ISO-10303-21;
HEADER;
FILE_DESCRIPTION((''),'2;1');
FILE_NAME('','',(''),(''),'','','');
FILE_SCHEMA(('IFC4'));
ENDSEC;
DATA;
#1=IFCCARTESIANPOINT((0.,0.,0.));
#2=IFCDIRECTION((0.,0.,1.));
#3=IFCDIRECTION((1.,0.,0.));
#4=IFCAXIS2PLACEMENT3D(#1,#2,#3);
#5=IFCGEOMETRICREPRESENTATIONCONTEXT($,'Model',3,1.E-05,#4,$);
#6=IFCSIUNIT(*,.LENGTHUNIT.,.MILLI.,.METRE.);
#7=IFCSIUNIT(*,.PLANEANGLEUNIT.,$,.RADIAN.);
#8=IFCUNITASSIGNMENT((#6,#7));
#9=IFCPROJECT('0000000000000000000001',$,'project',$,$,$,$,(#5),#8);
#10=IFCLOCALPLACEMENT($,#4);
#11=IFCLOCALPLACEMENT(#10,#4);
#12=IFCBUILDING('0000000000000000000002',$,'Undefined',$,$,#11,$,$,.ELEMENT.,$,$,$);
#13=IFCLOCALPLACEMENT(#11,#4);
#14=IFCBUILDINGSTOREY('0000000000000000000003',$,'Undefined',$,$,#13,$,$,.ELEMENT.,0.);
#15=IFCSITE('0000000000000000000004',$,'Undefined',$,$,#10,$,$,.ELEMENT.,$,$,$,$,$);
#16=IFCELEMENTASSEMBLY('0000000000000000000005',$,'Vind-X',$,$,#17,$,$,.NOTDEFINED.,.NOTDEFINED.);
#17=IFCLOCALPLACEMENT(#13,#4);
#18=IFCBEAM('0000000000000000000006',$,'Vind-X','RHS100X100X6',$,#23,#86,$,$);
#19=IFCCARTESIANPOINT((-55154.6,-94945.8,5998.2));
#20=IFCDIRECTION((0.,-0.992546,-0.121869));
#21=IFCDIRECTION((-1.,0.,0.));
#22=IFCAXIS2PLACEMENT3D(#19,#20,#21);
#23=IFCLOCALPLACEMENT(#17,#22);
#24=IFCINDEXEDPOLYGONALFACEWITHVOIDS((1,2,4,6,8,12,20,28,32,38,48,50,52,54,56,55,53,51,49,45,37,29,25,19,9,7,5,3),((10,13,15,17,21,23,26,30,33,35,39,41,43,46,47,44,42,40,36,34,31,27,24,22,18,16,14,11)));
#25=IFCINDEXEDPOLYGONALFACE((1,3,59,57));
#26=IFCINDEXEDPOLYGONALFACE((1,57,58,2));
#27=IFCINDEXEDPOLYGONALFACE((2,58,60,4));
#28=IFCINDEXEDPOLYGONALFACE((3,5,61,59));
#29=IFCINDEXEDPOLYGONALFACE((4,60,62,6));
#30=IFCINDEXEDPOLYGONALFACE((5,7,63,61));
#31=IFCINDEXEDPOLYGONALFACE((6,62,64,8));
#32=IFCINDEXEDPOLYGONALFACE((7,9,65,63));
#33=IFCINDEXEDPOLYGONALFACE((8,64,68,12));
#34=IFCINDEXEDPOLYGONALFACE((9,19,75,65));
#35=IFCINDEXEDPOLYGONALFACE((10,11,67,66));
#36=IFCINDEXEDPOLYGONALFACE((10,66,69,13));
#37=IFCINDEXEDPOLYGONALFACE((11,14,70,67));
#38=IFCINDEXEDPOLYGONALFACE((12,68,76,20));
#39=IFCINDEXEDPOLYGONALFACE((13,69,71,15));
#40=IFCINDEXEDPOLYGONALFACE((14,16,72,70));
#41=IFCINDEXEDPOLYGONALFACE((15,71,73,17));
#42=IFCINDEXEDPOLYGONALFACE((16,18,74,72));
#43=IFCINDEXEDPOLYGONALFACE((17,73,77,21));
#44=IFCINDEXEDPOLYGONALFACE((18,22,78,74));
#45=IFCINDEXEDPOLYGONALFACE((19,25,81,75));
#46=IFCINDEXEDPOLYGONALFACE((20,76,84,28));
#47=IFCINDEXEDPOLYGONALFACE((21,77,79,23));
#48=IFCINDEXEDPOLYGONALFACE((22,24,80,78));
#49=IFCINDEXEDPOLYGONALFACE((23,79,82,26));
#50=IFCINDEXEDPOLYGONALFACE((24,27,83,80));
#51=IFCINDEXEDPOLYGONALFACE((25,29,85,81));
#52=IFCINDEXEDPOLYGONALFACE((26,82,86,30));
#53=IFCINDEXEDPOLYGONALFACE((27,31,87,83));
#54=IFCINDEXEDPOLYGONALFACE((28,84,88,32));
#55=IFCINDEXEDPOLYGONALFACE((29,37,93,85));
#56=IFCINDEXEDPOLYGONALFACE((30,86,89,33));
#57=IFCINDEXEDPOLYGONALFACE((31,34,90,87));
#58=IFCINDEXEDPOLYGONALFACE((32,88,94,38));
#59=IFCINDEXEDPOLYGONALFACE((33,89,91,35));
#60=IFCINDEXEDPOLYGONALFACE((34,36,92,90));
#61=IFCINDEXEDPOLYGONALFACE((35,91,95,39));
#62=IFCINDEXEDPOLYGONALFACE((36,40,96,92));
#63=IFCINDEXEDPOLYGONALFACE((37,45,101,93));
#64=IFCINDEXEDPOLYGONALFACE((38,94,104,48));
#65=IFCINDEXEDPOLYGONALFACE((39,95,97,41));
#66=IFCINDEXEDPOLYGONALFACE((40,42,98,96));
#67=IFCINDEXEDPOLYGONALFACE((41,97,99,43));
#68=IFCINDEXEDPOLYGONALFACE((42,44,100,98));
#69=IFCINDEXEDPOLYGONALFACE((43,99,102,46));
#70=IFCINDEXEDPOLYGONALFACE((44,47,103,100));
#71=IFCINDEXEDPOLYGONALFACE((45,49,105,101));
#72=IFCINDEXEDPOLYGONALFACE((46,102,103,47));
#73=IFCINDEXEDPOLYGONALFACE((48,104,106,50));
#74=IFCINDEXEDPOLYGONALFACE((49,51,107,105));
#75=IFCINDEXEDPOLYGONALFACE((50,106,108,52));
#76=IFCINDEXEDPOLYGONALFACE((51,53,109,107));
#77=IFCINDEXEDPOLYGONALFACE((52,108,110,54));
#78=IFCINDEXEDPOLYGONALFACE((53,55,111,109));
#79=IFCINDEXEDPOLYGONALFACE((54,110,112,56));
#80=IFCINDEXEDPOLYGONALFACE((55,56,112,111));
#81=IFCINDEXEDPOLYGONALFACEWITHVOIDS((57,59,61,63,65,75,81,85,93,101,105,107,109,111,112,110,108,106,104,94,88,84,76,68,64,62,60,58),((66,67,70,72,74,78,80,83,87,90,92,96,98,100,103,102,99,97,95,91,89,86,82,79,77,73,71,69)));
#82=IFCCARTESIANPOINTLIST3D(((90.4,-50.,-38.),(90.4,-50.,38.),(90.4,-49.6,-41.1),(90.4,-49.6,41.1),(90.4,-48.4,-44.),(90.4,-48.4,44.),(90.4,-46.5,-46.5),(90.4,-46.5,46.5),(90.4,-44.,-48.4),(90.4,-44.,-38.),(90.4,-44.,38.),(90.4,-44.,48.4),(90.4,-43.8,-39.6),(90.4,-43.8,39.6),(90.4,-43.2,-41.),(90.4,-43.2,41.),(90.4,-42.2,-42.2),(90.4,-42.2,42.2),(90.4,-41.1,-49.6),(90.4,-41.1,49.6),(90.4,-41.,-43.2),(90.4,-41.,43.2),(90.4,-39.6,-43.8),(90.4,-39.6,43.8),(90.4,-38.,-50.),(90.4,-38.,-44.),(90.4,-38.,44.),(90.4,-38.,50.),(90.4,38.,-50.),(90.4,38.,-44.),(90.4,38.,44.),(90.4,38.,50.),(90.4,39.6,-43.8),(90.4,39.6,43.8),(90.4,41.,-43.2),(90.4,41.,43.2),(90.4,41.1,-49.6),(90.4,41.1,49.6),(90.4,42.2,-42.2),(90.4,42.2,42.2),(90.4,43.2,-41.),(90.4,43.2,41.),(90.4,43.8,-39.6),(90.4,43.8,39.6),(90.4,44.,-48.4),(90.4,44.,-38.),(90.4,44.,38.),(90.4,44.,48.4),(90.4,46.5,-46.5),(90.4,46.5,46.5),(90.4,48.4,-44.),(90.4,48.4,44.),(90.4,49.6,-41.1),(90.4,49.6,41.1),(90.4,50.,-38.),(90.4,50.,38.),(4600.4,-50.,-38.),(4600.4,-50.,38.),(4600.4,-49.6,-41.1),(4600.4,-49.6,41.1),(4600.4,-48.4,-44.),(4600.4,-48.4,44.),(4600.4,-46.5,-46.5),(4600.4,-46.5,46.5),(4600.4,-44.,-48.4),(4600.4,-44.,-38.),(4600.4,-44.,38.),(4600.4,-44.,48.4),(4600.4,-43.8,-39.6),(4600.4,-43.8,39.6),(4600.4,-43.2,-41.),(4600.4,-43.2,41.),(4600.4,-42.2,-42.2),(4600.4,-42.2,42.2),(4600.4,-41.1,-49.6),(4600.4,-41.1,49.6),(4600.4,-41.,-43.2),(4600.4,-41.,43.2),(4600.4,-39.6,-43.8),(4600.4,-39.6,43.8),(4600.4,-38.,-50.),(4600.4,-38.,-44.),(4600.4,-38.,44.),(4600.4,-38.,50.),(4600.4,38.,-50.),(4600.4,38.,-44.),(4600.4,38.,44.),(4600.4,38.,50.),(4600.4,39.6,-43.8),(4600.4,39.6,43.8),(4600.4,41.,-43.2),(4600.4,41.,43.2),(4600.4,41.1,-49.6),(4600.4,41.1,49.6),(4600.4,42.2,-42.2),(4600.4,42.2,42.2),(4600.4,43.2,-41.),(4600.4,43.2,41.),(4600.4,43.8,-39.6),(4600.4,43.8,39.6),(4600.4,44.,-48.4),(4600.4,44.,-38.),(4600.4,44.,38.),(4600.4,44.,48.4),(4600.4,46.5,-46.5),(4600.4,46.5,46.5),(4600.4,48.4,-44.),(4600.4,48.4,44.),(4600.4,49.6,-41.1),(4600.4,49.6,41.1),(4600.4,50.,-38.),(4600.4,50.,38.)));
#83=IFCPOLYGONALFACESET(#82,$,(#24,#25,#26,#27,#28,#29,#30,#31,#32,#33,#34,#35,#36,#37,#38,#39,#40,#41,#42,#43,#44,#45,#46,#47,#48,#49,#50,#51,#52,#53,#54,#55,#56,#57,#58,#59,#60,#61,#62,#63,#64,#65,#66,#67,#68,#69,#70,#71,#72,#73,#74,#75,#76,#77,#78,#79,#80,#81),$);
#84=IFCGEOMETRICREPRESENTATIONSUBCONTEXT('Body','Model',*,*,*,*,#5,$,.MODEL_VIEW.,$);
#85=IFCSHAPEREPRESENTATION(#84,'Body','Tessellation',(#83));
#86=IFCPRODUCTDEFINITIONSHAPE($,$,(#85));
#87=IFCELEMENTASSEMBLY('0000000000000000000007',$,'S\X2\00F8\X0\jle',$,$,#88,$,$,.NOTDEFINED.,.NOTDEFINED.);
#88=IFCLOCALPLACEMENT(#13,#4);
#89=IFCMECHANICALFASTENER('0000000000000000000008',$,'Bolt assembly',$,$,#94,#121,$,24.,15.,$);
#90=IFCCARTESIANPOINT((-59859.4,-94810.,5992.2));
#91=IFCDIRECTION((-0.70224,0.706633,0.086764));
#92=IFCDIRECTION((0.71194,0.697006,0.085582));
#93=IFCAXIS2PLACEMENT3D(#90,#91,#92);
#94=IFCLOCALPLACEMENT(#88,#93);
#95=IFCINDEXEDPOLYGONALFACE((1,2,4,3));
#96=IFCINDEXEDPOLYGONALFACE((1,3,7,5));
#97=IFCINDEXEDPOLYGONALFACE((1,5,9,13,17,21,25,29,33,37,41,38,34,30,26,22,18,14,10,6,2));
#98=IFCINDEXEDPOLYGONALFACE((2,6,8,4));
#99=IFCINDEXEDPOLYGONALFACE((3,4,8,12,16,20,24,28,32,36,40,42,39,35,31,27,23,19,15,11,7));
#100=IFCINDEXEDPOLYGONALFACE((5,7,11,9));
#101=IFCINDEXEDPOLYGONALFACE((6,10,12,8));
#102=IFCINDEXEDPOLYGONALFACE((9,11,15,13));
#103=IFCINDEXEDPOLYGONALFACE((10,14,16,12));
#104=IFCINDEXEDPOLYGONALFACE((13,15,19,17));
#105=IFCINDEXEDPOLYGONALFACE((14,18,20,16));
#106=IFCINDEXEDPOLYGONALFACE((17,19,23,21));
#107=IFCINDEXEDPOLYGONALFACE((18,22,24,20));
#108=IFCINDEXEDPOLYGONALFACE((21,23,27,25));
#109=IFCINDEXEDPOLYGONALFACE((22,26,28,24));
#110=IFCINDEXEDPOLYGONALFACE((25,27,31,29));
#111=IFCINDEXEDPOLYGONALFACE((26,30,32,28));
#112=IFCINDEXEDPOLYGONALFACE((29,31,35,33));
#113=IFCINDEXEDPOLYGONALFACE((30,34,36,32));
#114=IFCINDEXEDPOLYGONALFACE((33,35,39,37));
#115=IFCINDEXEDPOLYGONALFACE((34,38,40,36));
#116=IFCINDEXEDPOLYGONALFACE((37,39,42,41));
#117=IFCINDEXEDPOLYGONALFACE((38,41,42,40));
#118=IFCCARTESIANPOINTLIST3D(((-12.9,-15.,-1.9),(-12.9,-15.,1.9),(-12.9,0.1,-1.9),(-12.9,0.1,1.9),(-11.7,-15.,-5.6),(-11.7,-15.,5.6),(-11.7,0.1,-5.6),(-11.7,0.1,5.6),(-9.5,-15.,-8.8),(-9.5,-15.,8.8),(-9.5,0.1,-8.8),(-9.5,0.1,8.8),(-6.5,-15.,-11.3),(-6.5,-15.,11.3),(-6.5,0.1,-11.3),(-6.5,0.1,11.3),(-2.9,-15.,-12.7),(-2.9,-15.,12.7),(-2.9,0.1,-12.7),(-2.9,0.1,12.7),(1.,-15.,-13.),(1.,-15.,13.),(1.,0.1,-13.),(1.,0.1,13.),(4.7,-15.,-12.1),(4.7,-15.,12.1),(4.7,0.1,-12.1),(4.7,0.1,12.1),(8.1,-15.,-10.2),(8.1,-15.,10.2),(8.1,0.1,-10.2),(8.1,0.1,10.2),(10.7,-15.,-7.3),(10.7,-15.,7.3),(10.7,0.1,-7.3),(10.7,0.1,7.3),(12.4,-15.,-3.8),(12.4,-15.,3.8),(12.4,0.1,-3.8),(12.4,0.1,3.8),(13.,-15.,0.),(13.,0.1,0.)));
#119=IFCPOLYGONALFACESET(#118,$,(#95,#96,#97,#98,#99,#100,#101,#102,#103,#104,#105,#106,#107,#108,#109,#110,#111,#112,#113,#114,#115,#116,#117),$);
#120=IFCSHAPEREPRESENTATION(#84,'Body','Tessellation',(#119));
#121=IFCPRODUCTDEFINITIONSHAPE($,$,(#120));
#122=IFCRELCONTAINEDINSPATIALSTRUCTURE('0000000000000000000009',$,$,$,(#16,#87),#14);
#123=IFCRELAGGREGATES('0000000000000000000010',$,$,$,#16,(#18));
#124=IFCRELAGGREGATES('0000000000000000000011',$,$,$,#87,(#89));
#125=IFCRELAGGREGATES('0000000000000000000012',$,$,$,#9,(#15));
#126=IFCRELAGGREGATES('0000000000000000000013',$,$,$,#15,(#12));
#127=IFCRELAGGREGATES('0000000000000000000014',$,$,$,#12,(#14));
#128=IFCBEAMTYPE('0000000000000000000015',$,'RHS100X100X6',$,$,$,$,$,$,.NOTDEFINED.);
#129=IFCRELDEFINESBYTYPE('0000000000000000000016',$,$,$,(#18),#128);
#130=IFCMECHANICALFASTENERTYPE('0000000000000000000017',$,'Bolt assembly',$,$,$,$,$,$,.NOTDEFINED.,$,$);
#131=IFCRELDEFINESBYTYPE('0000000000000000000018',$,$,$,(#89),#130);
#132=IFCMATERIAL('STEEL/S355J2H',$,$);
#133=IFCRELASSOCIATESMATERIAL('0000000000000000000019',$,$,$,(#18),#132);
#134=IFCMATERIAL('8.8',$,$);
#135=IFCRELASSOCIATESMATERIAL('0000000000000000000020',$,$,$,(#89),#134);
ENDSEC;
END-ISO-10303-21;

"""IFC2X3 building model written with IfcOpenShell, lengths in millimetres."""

from ifc_helpers import new_model, si_unit, frame, origin_with_axes, origin_2d_with_axis, place, context, subcontext, project, spatial, hollow_rectangle, circle, extrude, clip, halfspace, source, transform, mapped, material, type_object, element, aggregate, save


model = new_model("IFC2X3")

# Units and contexts
model_context = context("Model", 3, precision=1e-05, world=origin_with_axes())
body_context = subcontext(model_context, "Body", "Model", "MODEL_VIEW")
ifc_project = project(units=[si_unit("LENGTHUNIT", "METRE", prefix="MILLI"), si_unit("PLANEANGLEUNIT", "RADIAN")], contexts=[model_context])

# Site, building, storey
site_placement = place(None, origin_with_axes())
site = spatial("IfcSite", under=ifc_project, at=site_placement, Name="Undefined", CompositionType="ELEMENT")
building_placement = place(site_placement, origin_with_axes())
building = spatial("IfcBuilding", under=site, at=building_placement, Name="Undefined", CompositionType="ELEMENT")
storey_placement = place(building_placement, origin_with_axes())
storey = spatial("IfcBuildingStorey", under=building, at=storey_placement, Name="Undefined", CompositionType="ELEMENT", Elevation=0.0)

# Shared definitions
ifc_material_1 = material(Name="STEEL/S355J2H")

# Element assembly, beam
assembly_1_placement = place(storey_placement, origin_with_axes())
assembly_1 = element("IfcElementAssembly", 1, at=assembly_1_placement, inside=storey, Name="Vind-X", AssemblyPlace="NOTDEFINED", PredefinedType="NOTDEFINED")
beam_type_1 = type_object("IfcBeamType", Name="RHS100X100X6", PredefinedType="NOTDEFINED")
beam_1_placement = place(assembly_1_placement, frame((-55154.6, -94945.8, 5998.2), z_axis=(0.0, -0.992546, -0.121869), x_axis=(-1.0, 0.0, 0.0)))
beam_1 = element("IfcBeam", 2, at=beam_1_placement, type_object=beam_type_1, material=ifc_material_1, Name="Vind-X", Description="RHS100X100X6", context=body_context, shape_type="Clipping", body=[
    clip(clip(extrude(hollow_rectangle(XDim=100.0, YDim=100.0, WallThickness=6.0, InnerFilletRadius=6.0, OuterFilletRadius=12.0, at=origin_2d_with_axis()), frame((4690.0, 0.0, 0.0), z_axis=(-1.0, 0.0, 0.0), x_axis=(0.0, -1.0, 0.0)), (0.0, 0.0, 1.0), 4690.0), halfspace(frame((4600.4, 7.5, 0.0), z_axis=(-1.0, 0.0, 0.0), x_axis=(0.0, 0.0, -1.0)), True)), halfspace(frame((90.4, 7.5, 0.0), z_axis=(1.0, 0.0, 0.0), x_axis=(0.0, 0.0, 1.0)), True)),
])

# Shared definitions
ifc_material_2 = material(Name="8.8")
mechanical_fastener_type = type_object("IfcMechanicalFastenerType", Name="Bolt assembly")

aggregate(assembly_1, [beam_1])

# Element assembly, mechanical fastener
assembly_2_placement = place(storey_placement, origin_with_axes())
assembly_2 = element("IfcElementAssembly", 3, at=assembly_2_placement, inside=storey, Name="Søjle", AssemblyPlace="NOTDEFINED", PredefinedType="NOTDEFINED")
shared_shape_1 = source(origin_with_axes(), body_context, "Body", "SweptSolid", [
    extrude(circle(Radius=13.0, at=origin_2d_with_axis()), frame((0.0, -15.0, 0.0), z_axis=(0.0, 1.0, 0.0), x_axis=(1.0, 0.0, 0.0)), (0.0, 0.0, 1.0), 15.1),
])
mechanical_fastener_1_placement = place(assembly_2_placement, frame((-59859.4, -94810.0, 5992.2), z_axis=(-0.70224, 0.706633, 0.086764), x_axis=(0.71194, 0.697006, 0.085582)))
mechanical_fastener_1 = element("IfcMechanicalFastener", 4, at=mechanical_fastener_1_placement, type_object=mechanical_fastener_type, material=ifc_material_2, Name="Bolt assembly", NominalDiameter=24.0, NominalLength=15.0, context=body_context, shape_type="MappedRepresentation", body=[
    mapped(shared_shape_1, transform((0.0, 0.0, 0.0))),
])
aggregate(assembly_2, [mechanical_fastener_1])

save(model, "model.ifc")
